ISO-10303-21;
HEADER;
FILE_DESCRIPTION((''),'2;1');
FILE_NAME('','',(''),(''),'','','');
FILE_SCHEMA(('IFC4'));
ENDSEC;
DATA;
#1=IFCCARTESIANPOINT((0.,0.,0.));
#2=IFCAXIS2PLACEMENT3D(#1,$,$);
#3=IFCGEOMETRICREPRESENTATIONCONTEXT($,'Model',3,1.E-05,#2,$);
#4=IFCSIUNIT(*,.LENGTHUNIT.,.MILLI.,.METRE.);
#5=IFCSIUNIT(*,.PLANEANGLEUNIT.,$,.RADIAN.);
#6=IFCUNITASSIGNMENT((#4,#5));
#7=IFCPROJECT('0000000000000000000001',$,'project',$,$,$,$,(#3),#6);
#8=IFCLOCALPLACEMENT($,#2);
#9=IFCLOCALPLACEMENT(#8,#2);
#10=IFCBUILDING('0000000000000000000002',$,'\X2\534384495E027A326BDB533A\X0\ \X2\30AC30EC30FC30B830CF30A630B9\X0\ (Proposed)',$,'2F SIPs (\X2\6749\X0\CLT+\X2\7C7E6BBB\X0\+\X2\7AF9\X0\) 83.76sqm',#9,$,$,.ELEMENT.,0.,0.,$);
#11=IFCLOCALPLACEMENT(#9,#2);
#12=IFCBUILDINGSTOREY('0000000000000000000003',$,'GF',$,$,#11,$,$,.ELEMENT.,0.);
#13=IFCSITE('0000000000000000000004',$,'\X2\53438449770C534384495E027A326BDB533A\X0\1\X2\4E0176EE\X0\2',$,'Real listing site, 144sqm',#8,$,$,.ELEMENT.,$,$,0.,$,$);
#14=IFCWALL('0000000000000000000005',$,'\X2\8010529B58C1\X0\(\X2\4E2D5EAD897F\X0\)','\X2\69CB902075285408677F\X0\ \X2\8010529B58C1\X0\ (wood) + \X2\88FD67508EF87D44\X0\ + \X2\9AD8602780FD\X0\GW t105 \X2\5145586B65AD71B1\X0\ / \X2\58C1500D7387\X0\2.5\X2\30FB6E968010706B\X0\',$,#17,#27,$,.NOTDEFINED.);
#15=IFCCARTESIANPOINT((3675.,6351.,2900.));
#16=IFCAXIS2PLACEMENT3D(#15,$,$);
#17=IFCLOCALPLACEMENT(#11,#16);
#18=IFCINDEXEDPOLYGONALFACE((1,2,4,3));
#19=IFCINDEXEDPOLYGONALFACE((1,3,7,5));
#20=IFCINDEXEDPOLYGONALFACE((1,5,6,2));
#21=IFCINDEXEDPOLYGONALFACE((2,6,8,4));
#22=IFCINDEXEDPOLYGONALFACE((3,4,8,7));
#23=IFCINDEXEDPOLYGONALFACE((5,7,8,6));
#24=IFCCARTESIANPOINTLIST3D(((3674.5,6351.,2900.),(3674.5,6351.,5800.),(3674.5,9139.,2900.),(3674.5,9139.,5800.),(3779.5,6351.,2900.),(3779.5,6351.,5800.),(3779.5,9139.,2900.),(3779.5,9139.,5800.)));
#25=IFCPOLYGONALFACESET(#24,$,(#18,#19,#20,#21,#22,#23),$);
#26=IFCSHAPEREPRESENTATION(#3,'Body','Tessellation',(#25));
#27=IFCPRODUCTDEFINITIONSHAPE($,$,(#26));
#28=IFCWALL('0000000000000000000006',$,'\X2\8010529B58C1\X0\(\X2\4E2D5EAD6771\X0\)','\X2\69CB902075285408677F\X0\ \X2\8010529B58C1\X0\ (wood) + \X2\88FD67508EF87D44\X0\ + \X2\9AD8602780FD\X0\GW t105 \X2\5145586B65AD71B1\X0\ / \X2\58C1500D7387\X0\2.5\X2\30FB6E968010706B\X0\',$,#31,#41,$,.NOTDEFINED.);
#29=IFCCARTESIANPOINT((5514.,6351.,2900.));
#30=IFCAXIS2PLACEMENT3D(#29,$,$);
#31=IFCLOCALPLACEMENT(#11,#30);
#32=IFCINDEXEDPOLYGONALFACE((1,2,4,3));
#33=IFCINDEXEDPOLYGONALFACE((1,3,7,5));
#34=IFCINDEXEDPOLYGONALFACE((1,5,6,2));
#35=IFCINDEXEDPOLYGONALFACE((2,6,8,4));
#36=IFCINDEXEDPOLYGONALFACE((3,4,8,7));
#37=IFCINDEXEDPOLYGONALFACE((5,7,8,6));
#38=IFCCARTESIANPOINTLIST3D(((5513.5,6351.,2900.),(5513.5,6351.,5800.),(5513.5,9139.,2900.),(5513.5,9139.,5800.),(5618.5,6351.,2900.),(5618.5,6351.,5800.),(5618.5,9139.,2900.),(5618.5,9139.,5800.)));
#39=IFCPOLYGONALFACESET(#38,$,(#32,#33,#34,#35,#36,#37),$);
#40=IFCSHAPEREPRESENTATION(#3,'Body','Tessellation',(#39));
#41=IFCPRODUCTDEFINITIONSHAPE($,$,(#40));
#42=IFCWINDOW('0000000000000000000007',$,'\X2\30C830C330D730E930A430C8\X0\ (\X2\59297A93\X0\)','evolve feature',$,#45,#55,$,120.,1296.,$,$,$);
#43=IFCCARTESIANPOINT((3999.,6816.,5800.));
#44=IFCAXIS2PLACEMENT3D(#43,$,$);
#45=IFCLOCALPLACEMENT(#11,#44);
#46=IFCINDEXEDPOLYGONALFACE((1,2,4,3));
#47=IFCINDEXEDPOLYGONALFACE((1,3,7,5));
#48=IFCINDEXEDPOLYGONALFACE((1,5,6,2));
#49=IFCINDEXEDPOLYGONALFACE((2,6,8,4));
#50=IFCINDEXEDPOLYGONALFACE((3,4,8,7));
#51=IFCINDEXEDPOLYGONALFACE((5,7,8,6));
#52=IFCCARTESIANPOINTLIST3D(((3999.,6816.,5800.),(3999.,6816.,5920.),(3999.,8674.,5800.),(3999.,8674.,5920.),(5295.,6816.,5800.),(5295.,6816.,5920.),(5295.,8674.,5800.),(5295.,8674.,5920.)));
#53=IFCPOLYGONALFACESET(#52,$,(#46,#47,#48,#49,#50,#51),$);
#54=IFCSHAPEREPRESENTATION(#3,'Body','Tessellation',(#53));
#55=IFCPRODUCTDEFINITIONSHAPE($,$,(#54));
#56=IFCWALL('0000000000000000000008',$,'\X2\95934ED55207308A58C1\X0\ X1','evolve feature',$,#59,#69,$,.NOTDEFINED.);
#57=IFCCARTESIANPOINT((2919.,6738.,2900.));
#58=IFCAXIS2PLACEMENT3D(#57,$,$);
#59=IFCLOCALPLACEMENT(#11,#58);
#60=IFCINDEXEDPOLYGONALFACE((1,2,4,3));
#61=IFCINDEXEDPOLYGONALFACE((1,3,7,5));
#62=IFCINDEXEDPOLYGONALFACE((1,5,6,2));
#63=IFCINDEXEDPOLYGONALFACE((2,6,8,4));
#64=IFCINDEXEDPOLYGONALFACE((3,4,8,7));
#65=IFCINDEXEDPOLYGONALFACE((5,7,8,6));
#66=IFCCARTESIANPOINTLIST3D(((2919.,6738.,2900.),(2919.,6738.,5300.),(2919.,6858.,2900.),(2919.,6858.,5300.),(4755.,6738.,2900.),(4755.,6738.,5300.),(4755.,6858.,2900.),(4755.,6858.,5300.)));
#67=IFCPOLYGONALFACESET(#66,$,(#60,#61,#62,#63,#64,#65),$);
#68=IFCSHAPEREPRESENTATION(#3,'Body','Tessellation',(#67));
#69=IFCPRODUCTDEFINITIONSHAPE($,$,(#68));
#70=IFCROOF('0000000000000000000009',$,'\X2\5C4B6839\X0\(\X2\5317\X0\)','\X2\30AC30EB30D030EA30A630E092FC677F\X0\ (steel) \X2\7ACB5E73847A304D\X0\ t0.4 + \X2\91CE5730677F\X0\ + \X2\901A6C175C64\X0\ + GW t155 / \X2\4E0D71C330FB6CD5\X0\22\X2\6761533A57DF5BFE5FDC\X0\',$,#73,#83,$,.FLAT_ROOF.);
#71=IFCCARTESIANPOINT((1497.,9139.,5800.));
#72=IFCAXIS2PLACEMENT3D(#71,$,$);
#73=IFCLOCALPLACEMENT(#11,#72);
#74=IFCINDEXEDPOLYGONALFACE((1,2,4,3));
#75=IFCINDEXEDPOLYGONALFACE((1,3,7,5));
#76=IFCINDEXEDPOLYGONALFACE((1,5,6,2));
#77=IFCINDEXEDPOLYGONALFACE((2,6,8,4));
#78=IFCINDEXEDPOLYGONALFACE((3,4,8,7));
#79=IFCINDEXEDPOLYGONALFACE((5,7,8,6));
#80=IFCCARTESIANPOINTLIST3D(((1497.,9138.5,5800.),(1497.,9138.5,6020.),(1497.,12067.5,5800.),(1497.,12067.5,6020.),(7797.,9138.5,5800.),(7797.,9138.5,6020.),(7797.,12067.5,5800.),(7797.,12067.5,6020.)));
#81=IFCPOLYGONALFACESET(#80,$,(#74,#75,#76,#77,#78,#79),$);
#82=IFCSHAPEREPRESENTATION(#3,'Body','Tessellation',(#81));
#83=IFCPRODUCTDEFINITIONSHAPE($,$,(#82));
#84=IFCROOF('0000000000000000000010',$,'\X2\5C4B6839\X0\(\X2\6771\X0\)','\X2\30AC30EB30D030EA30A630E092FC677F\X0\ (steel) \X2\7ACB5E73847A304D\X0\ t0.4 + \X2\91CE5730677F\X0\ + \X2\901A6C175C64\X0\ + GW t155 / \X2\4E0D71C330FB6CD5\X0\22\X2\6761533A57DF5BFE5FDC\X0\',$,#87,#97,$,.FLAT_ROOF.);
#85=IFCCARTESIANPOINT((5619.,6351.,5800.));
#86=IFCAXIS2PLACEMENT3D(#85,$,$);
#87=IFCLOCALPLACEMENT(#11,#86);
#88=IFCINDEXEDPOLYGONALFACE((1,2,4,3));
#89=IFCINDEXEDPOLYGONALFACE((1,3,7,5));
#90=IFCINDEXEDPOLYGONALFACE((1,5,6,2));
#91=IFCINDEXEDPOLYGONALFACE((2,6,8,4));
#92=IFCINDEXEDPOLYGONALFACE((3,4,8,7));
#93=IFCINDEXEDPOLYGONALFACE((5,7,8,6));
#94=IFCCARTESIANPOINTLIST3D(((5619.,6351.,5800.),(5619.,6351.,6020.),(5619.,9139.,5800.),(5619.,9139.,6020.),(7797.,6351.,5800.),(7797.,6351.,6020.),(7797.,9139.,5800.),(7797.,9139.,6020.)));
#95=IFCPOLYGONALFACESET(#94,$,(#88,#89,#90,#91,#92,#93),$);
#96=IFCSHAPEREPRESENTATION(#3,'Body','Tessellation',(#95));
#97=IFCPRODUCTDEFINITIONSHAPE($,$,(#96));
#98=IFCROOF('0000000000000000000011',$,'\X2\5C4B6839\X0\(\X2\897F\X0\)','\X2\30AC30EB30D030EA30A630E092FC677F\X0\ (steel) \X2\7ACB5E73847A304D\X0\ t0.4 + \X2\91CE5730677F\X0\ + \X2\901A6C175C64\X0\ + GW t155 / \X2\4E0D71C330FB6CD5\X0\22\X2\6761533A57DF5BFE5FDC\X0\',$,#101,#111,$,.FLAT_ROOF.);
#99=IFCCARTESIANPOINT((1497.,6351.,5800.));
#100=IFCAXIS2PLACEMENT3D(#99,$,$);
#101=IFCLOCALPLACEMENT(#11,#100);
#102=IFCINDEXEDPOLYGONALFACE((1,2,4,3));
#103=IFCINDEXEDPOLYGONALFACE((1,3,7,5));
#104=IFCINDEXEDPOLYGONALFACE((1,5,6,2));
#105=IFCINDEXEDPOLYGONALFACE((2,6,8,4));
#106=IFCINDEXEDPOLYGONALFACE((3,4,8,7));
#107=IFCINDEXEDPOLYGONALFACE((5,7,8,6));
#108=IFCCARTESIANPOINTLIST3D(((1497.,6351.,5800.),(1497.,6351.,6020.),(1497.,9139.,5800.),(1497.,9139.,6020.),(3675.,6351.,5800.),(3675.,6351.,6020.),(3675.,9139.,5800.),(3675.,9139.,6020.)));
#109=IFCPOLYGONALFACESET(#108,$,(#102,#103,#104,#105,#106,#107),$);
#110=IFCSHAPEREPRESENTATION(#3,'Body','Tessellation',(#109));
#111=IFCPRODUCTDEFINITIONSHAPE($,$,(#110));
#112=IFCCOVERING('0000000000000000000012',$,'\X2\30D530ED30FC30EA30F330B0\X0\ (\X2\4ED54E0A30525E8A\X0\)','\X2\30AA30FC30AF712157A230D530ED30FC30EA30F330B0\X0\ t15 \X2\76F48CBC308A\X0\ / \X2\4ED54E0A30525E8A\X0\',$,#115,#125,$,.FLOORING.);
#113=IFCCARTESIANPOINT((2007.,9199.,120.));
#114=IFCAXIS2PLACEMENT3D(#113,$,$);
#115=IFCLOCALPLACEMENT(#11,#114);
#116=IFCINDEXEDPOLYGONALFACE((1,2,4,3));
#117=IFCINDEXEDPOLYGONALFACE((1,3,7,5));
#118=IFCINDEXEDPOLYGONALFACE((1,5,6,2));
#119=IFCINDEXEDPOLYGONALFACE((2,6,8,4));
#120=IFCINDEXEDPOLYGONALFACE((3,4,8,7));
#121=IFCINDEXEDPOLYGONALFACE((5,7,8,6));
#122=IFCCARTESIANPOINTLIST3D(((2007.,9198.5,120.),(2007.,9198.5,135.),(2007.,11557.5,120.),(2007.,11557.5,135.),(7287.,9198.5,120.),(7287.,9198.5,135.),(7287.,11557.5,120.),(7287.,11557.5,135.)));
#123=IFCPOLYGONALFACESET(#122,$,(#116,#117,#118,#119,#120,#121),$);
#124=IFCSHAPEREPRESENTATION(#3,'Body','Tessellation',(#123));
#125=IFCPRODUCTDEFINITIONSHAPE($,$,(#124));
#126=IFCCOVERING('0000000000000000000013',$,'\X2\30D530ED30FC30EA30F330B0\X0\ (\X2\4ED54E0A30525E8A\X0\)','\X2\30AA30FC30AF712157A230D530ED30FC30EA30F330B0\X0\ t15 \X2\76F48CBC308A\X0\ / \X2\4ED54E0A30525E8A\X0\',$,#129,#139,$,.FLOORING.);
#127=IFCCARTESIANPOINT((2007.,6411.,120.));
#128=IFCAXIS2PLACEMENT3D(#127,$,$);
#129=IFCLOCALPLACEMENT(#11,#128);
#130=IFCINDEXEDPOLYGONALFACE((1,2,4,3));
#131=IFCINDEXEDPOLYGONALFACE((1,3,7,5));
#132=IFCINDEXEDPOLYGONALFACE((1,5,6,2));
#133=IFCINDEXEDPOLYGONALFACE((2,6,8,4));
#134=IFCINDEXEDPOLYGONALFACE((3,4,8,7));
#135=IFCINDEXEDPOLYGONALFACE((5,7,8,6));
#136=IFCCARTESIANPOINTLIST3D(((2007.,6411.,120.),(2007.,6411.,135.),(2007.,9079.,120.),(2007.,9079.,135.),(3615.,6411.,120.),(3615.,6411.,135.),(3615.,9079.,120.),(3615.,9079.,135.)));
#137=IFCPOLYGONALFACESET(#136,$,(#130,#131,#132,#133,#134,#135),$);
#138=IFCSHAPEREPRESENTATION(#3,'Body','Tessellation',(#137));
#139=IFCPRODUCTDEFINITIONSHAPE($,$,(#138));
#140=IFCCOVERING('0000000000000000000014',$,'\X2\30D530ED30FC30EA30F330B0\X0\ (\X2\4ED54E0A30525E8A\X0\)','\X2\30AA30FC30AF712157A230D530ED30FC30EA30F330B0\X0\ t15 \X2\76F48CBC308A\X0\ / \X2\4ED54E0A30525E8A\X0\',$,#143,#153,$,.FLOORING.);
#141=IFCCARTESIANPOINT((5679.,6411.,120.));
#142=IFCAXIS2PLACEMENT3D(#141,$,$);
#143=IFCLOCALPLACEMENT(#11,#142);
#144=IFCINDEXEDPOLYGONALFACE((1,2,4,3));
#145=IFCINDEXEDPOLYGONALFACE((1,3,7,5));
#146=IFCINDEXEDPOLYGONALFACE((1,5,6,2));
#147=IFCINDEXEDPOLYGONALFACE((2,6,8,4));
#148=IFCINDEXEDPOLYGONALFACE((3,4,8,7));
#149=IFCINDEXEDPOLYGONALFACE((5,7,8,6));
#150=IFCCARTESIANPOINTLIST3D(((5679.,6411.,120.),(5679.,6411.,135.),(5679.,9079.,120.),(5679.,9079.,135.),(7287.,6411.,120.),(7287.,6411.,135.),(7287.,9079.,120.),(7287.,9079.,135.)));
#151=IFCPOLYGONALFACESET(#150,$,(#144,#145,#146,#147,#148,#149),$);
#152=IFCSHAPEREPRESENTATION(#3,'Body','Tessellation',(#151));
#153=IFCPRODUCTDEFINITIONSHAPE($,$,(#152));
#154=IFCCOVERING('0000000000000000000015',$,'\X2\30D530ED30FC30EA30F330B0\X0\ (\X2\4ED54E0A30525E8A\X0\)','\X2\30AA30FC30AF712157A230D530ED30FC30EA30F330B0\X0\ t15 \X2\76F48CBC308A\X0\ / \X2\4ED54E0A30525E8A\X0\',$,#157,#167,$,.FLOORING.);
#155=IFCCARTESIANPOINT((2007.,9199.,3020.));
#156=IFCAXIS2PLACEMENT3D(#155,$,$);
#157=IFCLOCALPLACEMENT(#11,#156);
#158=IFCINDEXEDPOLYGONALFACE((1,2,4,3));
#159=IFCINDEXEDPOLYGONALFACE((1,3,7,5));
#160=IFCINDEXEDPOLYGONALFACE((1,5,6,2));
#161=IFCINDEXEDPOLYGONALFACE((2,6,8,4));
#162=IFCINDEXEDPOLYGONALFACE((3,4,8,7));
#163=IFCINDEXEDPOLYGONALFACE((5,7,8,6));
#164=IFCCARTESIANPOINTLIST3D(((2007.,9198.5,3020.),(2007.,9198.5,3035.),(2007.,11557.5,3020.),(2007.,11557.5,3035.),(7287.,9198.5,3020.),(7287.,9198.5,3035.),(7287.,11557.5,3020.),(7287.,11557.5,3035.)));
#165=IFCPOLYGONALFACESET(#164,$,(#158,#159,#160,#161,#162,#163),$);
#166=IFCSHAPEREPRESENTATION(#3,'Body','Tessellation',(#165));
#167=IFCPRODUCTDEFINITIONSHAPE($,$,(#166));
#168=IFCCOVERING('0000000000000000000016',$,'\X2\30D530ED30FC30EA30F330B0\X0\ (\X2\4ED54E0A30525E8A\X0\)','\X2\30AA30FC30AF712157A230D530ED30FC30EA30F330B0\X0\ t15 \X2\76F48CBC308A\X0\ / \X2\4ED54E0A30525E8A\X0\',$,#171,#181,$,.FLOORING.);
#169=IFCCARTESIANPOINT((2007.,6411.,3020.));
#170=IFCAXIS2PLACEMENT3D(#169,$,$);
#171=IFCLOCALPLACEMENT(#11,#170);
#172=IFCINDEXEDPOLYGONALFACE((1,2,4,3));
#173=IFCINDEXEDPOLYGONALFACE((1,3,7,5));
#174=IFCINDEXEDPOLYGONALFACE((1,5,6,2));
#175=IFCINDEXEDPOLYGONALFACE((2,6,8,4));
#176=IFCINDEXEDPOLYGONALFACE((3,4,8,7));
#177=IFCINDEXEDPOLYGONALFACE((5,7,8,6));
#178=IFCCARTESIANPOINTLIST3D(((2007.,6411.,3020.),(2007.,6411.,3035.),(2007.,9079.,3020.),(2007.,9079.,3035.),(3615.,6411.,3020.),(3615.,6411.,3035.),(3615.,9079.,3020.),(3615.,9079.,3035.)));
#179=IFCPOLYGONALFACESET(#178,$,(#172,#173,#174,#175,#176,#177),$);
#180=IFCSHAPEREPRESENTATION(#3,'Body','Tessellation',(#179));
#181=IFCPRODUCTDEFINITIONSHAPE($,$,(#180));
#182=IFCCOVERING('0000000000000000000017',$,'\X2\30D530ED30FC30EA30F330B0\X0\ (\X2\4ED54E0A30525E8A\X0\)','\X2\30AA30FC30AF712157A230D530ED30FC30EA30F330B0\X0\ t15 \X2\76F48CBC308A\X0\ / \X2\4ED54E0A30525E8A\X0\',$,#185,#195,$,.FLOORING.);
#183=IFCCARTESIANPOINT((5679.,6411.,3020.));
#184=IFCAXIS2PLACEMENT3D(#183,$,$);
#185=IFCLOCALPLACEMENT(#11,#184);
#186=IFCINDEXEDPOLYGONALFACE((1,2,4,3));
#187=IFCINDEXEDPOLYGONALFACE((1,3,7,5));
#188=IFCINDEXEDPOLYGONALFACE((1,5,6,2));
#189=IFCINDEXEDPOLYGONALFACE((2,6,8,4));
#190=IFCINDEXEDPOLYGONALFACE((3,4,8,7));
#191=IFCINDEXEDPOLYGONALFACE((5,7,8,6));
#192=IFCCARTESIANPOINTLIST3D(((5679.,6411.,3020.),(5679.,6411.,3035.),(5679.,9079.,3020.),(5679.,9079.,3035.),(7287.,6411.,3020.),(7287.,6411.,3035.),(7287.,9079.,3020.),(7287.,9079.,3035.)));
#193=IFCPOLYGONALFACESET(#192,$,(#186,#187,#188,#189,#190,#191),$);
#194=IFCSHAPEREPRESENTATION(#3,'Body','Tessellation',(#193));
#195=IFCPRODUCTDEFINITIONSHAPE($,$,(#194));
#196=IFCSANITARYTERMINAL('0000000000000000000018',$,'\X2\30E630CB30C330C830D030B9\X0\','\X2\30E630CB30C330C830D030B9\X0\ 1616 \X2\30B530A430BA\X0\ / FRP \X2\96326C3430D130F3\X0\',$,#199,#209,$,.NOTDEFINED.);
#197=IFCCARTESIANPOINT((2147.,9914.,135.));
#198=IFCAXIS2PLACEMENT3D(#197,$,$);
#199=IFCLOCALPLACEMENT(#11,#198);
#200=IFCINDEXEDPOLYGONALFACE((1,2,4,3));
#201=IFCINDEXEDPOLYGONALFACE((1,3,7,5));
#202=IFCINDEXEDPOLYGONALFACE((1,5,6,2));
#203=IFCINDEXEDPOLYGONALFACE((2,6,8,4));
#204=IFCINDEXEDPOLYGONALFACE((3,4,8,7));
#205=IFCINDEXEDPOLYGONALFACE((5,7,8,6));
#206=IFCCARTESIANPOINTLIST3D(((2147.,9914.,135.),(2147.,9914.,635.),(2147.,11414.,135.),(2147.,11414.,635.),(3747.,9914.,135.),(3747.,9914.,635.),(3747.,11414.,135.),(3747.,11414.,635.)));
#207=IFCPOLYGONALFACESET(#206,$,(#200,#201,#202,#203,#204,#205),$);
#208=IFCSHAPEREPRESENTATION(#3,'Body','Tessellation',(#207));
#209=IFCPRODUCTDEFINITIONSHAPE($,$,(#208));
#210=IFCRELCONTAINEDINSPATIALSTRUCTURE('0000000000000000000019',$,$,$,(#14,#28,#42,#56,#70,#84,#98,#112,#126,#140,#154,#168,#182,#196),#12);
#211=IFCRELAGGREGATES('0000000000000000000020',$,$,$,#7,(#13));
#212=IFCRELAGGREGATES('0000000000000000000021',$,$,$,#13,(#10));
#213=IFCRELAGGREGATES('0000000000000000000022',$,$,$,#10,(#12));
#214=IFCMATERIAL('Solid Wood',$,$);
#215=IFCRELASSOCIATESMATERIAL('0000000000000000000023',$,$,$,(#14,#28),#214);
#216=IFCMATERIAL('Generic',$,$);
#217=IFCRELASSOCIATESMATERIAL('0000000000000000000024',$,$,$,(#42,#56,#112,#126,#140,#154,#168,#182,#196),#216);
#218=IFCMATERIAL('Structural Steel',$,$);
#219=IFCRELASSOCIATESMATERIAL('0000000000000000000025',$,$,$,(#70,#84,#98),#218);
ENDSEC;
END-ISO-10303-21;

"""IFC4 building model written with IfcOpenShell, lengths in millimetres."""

from ifc_helpers import new_model, si_unit, frame, frame_2d, origin, place, context, project, spatial, rectangle, extrude, material, element, save


model = new_model("IFC4")

# Units and contexts
model_context = context("Model", 3, precision=1e-05, world=origin())
ifc_project = project(units=[si_unit("LENGTHUNIT", "METRE", prefix="MILLI"), si_unit("PLANEANGLEUNIT", "RADIAN")], contexts=[model_context])

# Site, building, storey
site_placement = place(None, origin())
site = spatial("IfcSite", under=ifc_project, at=site_placement, Name="千葉県千葉市稲毛区1丁目2", ObjectType="Real listing site, 144sqm", CompositionType="ELEMENT", RefElevation=0.0)
building_placement = place(site_placement, origin())
building = spatial("IfcBuilding", under=site, at=building_placement, Name="千葉市稲毛区 ガレージハウス (Proposed)", ObjectType="2F SIPs (杉CLT+籾殻+竹) 83.76sqm", CompositionType="ELEMENT", ElevationOfRefHeight=0.0, ElevationOfTerrain=0.0)
storey_placement = place(building_placement, origin())
storey = spatial("IfcBuildingStorey", under=building, at=storey_placement, Name="GF", CompositionType="ELEMENT", Elevation=0.0)

# Shared definitions
ifc_material_1 = material(Name="Solid Wood")

# Walls
wall_1_placement = place(storey_placement, frame((3675.0, 6351.0, 2900.0)))
element("IfcWall", 1, at=wall_1_placement, inside=storey, material=ifc_material_1, Name="耐力壁(中庭西)", Description="構造用合板 耐力壁 (wood) + 製材軸組 + 高性能GW t105 充填断熱 / 壁倍率2.5・準耐火", PredefinedType="NOTDEFINED", context=model_context, shape_type="SweptSolid", body=[
    extrude(rectangle(XDim=105.0, YDim=2788.0, at=frame_2d((52.0, 1394.0))), frame((3675.0, 6351.0, 2900.0)), (0.0, 0.0, 1.0), 2900.0),
])
wall_2_placement = place(storey_placement, frame((5514.0, 6351.0, 2900.0)))
element("IfcWall", 2, at=wall_2_placement, inside=storey, material=ifc_material_1, Name="耐力壁(中庭東)", Description="構造用合板 耐力壁 (wood) + 製材軸組 + 高性能GW t105 充填断熱 / 壁倍率2.5・準耐火", PredefinedType="NOTDEFINED", context=model_context, shape_type="SweptSolid", body=[
    extrude(rectangle(XDim=105.0, YDim=2788.0, at=frame_2d((52.0, 1394.0))), frame((5514.0, 6351.0, 2900.0)), (0.0, 0.0, 1.0), 2900.0),
])

# Window
ifc_material_2 = material(Name="Generic")
window_1_placement = place(storey_placement, frame((3999.0, 6816.0, 5800.0)))
element("IfcWindow", 3, at=window_1_placement, inside=storey, material=ifc_material_2, Name="トップライト (天窓)", Description="evolve feature", OverallHeight=120.0, OverallWidth=1296.0, context=model_context, shape_type="SweptSolid", body=[
    extrude(rectangle(XDim=1296.0, YDim=1858.0, at=frame_2d((648.0, 929.0))), frame((3999.0, 6816.0, 5800.0)), (0.0, 0.0, 1.0), 120.0),
])

# Wall
wall_3_placement = place(storey_placement, frame((2919.0, 6738.0, 2900.0)))
element("IfcWall", 4, at=wall_3_placement, inside=storey, material=ifc_material_2, Name="間仕切り壁 X1", Description="evolve feature", PredefinedType="NOTDEFINED", context=model_context, shape_type="SweptSolid", body=[
    extrude(rectangle(XDim=1836.0, YDim=120.0, at=frame_2d((918.0, 60.0))), frame((2919.0, 6738.0, 2900.0)), (0.0, 0.0, 1.0), 2400.0),
])

# Roofs
ifc_material_3 = material(Name="Structural Steel")
roof_1_placement = place(storey_placement, frame((1497.0, 9139.0, 5800.0)))
element("IfcRoof", 5, at=roof_1_placement, inside=storey, material=ifc_material_3, Name="屋根(北)", Description="ガルバリウム鋼板 (steel) 立平葺き t0.4 + 野地板 + 通気層 + GW t155 / 不燃・法22条区域対応", PredefinedType="FLAT_ROOF", context=model_context, shape_type="SweptSolid", body=[
    extrude(rectangle(XDim=6300.0, YDim=2929.0, at=frame_2d((3150.0, 1464.0))), frame((1497.0, 9139.0, 5800.0)), (0.0, 0.0, 1.0), 220.0),
])
roof_2_placement = place(storey_placement, frame((5619.0, 6351.0, 5800.0)))
element("IfcRoof", 6, at=roof_2_placement, inside=storey, material=ifc_material_3, Name="屋根(東)", Description="ガルバリウム鋼板 (steel) 立平葺き t0.4 + 野地板 + 通気層 + GW t155 / 不燃・法22条区域対応", PredefinedType="FLAT_ROOF", context=model_context, shape_type="SweptSolid", body=[
    extrude(rectangle(XDim=2178.0, YDim=2788.0, at=frame_2d((1089.0, 1394.0))), frame((5619.0, 6351.0, 5800.0)), (0.0, 0.0, 1.0), 220.0),
])
roof_3_placement = place(storey_placement, frame((1497.0, 6351.0, 5800.0)))
element("IfcRoof", 7, at=roof_3_placement, inside=storey, material=ifc_material_3, Name="屋根(西)", Description="ガルバリウム鋼板 (steel) 立平葺き t0.4 + 野地板 + 通気層 + GW t155 / 不燃・法22条区域対応", PredefinedType="FLAT_ROOF", context=model_context, shape_type="SweptSolid", body=[
    extrude(rectangle(XDim=2178.0, YDim=2788.0, at=frame_2d((1089.0, 1394.0))), frame((1497.0, 6351.0, 5800.0)), (0.0, 0.0, 1.0), 220.0),
])

# Coverings
covering_1_placement = place(storey_placement, frame((2007.0, 9199.0, 120.0)))
element("IfcCovering", 8, at=covering_1_placement, inside=storey, material=ifc_material_2, Name="フローリング (仕上げ床)", Description="オーク無垢フローリング t15 直貼り / 仕上げ床", PredefinedType="FLOORING", context=model_context, shape_type="SweptSolid", body=[
    extrude(rectangle(XDim=5280.0, YDim=2359.0, at=frame_2d((2640.0, 1179.0))), frame((2007.0, 9199.0, 120.0)), (0.0, 0.0, 1.0), 15.0),
])
covering_2_placement = place(storey_placement, frame((2007.0, 6411.0, 120.0)))
element("IfcCovering", 9, at=covering_2_placement, inside=storey, material=ifc_material_2, Name="フローリング (仕上げ床)", Description="オーク無垢フローリング t15 直貼り / 仕上げ床", PredefinedType="FLOORING", context=model_context, shape_type="SweptSolid", body=[
    extrude(rectangle(XDim=1608.0, YDim=2668.0, at=frame_2d((804.0, 1334.0))), frame((2007.0, 6411.0, 120.0)), (0.0, 0.0, 1.0), 15.0),
])
covering_3_placement = place(storey_placement, frame((5679.0, 6411.0, 120.0)))
element("IfcCovering", 10, at=covering_3_placement, inside=storey, material=ifc_material_2, Name="フローリング (仕上げ床)", Description="オーク無垢フローリング t15 直貼り / 仕上げ床", PredefinedType="FLOORING", context=model_context, shape_type="SweptSolid", body=[
    extrude(rectangle(XDim=1608.0, YDim=2668.0, at=frame_2d((804.0, 1334.0))), frame((5679.0, 6411.0, 120.0)), (0.0, 0.0, 1.0), 15.0),
])
covering_4_placement = place(storey_placement, frame((2007.0, 9199.0, 3020.0)))
element("IfcCovering", 11, at=covering_4_placement, inside=storey, material=ifc_material_2, Name="フローリング (仕上げ床)", Description="オーク無垢フローリング t15 直貼り / 仕上げ床", PredefinedType="FLOORING", context=model_context, shape_type="SweptSolid", body=[
    extrude(rectangle(XDim=5280.0, YDim=2359.0, at=frame_2d((2640.0, 1179.0))), frame((2007.0, 9199.0, 3020.0)), (0.0, 0.0, 1.0), 15.0),
])
covering_5_placement = place(storey_placement, frame((2007.0, 6411.0, 3020.0)))
element("IfcCovering", 12, at=covering_5_placement, inside=storey, material=ifc_material_2, Name="フローリング (仕上げ床)", Description="オーク無垢フローリング t15 直貼り / 仕上げ床", PredefinedType="FLOORING", context=model_context, shape_type="SweptSolid", body=[
    extrude(rectangle(XDim=1608.0, YDim=2668.0, at=frame_2d((804.0, 1334.0))), frame((2007.0, 6411.0, 3020.0)), (0.0, 0.0, 1.0), 15.0),
])
covering_6_placement = place(storey_placement, frame((5679.0, 6411.0, 3020.0)))
element("IfcCovering", 13, at=covering_6_placement, inside=storey, material=ifc_material_2, Name="フローリング (仕上げ床)", Description="オーク無垢フローリング t15 直貼り / 仕上げ床", PredefinedType="FLOORING", context=model_context, shape_type="SweptSolid", body=[
    extrude(rectangle(XDim=1608.0, YDim=2668.0, at=frame_2d((804.0, 1334.0))), frame((5679.0, 6411.0, 3020.0)), (0.0, 0.0, 1.0), 15.0),
])

# Sanitary terminal
sanitary_terminal_1_placement = place(storey_placement, frame((2147.0, 9914.0, 135.0)))
element("IfcSanitaryTerminal", 14, at=sanitary_terminal_1_placement, inside=storey, material=ifc_material_2, Name="ユニットバス", Description="ユニットバス 1616 サイズ / FRP 防水パン", PredefinedType="NOTDEFINED", context=model_context, shape_type="SweptSolid", body=[
    extrude(rectangle(XDim=1600.0, YDim=1500.0, at=frame_2d((800.0, 750.0))), frame((2147.0, 9914.0, 135.0)), (0.0, 0.0, 1.0), 500.0),
])

save(model, "model.ifc")
